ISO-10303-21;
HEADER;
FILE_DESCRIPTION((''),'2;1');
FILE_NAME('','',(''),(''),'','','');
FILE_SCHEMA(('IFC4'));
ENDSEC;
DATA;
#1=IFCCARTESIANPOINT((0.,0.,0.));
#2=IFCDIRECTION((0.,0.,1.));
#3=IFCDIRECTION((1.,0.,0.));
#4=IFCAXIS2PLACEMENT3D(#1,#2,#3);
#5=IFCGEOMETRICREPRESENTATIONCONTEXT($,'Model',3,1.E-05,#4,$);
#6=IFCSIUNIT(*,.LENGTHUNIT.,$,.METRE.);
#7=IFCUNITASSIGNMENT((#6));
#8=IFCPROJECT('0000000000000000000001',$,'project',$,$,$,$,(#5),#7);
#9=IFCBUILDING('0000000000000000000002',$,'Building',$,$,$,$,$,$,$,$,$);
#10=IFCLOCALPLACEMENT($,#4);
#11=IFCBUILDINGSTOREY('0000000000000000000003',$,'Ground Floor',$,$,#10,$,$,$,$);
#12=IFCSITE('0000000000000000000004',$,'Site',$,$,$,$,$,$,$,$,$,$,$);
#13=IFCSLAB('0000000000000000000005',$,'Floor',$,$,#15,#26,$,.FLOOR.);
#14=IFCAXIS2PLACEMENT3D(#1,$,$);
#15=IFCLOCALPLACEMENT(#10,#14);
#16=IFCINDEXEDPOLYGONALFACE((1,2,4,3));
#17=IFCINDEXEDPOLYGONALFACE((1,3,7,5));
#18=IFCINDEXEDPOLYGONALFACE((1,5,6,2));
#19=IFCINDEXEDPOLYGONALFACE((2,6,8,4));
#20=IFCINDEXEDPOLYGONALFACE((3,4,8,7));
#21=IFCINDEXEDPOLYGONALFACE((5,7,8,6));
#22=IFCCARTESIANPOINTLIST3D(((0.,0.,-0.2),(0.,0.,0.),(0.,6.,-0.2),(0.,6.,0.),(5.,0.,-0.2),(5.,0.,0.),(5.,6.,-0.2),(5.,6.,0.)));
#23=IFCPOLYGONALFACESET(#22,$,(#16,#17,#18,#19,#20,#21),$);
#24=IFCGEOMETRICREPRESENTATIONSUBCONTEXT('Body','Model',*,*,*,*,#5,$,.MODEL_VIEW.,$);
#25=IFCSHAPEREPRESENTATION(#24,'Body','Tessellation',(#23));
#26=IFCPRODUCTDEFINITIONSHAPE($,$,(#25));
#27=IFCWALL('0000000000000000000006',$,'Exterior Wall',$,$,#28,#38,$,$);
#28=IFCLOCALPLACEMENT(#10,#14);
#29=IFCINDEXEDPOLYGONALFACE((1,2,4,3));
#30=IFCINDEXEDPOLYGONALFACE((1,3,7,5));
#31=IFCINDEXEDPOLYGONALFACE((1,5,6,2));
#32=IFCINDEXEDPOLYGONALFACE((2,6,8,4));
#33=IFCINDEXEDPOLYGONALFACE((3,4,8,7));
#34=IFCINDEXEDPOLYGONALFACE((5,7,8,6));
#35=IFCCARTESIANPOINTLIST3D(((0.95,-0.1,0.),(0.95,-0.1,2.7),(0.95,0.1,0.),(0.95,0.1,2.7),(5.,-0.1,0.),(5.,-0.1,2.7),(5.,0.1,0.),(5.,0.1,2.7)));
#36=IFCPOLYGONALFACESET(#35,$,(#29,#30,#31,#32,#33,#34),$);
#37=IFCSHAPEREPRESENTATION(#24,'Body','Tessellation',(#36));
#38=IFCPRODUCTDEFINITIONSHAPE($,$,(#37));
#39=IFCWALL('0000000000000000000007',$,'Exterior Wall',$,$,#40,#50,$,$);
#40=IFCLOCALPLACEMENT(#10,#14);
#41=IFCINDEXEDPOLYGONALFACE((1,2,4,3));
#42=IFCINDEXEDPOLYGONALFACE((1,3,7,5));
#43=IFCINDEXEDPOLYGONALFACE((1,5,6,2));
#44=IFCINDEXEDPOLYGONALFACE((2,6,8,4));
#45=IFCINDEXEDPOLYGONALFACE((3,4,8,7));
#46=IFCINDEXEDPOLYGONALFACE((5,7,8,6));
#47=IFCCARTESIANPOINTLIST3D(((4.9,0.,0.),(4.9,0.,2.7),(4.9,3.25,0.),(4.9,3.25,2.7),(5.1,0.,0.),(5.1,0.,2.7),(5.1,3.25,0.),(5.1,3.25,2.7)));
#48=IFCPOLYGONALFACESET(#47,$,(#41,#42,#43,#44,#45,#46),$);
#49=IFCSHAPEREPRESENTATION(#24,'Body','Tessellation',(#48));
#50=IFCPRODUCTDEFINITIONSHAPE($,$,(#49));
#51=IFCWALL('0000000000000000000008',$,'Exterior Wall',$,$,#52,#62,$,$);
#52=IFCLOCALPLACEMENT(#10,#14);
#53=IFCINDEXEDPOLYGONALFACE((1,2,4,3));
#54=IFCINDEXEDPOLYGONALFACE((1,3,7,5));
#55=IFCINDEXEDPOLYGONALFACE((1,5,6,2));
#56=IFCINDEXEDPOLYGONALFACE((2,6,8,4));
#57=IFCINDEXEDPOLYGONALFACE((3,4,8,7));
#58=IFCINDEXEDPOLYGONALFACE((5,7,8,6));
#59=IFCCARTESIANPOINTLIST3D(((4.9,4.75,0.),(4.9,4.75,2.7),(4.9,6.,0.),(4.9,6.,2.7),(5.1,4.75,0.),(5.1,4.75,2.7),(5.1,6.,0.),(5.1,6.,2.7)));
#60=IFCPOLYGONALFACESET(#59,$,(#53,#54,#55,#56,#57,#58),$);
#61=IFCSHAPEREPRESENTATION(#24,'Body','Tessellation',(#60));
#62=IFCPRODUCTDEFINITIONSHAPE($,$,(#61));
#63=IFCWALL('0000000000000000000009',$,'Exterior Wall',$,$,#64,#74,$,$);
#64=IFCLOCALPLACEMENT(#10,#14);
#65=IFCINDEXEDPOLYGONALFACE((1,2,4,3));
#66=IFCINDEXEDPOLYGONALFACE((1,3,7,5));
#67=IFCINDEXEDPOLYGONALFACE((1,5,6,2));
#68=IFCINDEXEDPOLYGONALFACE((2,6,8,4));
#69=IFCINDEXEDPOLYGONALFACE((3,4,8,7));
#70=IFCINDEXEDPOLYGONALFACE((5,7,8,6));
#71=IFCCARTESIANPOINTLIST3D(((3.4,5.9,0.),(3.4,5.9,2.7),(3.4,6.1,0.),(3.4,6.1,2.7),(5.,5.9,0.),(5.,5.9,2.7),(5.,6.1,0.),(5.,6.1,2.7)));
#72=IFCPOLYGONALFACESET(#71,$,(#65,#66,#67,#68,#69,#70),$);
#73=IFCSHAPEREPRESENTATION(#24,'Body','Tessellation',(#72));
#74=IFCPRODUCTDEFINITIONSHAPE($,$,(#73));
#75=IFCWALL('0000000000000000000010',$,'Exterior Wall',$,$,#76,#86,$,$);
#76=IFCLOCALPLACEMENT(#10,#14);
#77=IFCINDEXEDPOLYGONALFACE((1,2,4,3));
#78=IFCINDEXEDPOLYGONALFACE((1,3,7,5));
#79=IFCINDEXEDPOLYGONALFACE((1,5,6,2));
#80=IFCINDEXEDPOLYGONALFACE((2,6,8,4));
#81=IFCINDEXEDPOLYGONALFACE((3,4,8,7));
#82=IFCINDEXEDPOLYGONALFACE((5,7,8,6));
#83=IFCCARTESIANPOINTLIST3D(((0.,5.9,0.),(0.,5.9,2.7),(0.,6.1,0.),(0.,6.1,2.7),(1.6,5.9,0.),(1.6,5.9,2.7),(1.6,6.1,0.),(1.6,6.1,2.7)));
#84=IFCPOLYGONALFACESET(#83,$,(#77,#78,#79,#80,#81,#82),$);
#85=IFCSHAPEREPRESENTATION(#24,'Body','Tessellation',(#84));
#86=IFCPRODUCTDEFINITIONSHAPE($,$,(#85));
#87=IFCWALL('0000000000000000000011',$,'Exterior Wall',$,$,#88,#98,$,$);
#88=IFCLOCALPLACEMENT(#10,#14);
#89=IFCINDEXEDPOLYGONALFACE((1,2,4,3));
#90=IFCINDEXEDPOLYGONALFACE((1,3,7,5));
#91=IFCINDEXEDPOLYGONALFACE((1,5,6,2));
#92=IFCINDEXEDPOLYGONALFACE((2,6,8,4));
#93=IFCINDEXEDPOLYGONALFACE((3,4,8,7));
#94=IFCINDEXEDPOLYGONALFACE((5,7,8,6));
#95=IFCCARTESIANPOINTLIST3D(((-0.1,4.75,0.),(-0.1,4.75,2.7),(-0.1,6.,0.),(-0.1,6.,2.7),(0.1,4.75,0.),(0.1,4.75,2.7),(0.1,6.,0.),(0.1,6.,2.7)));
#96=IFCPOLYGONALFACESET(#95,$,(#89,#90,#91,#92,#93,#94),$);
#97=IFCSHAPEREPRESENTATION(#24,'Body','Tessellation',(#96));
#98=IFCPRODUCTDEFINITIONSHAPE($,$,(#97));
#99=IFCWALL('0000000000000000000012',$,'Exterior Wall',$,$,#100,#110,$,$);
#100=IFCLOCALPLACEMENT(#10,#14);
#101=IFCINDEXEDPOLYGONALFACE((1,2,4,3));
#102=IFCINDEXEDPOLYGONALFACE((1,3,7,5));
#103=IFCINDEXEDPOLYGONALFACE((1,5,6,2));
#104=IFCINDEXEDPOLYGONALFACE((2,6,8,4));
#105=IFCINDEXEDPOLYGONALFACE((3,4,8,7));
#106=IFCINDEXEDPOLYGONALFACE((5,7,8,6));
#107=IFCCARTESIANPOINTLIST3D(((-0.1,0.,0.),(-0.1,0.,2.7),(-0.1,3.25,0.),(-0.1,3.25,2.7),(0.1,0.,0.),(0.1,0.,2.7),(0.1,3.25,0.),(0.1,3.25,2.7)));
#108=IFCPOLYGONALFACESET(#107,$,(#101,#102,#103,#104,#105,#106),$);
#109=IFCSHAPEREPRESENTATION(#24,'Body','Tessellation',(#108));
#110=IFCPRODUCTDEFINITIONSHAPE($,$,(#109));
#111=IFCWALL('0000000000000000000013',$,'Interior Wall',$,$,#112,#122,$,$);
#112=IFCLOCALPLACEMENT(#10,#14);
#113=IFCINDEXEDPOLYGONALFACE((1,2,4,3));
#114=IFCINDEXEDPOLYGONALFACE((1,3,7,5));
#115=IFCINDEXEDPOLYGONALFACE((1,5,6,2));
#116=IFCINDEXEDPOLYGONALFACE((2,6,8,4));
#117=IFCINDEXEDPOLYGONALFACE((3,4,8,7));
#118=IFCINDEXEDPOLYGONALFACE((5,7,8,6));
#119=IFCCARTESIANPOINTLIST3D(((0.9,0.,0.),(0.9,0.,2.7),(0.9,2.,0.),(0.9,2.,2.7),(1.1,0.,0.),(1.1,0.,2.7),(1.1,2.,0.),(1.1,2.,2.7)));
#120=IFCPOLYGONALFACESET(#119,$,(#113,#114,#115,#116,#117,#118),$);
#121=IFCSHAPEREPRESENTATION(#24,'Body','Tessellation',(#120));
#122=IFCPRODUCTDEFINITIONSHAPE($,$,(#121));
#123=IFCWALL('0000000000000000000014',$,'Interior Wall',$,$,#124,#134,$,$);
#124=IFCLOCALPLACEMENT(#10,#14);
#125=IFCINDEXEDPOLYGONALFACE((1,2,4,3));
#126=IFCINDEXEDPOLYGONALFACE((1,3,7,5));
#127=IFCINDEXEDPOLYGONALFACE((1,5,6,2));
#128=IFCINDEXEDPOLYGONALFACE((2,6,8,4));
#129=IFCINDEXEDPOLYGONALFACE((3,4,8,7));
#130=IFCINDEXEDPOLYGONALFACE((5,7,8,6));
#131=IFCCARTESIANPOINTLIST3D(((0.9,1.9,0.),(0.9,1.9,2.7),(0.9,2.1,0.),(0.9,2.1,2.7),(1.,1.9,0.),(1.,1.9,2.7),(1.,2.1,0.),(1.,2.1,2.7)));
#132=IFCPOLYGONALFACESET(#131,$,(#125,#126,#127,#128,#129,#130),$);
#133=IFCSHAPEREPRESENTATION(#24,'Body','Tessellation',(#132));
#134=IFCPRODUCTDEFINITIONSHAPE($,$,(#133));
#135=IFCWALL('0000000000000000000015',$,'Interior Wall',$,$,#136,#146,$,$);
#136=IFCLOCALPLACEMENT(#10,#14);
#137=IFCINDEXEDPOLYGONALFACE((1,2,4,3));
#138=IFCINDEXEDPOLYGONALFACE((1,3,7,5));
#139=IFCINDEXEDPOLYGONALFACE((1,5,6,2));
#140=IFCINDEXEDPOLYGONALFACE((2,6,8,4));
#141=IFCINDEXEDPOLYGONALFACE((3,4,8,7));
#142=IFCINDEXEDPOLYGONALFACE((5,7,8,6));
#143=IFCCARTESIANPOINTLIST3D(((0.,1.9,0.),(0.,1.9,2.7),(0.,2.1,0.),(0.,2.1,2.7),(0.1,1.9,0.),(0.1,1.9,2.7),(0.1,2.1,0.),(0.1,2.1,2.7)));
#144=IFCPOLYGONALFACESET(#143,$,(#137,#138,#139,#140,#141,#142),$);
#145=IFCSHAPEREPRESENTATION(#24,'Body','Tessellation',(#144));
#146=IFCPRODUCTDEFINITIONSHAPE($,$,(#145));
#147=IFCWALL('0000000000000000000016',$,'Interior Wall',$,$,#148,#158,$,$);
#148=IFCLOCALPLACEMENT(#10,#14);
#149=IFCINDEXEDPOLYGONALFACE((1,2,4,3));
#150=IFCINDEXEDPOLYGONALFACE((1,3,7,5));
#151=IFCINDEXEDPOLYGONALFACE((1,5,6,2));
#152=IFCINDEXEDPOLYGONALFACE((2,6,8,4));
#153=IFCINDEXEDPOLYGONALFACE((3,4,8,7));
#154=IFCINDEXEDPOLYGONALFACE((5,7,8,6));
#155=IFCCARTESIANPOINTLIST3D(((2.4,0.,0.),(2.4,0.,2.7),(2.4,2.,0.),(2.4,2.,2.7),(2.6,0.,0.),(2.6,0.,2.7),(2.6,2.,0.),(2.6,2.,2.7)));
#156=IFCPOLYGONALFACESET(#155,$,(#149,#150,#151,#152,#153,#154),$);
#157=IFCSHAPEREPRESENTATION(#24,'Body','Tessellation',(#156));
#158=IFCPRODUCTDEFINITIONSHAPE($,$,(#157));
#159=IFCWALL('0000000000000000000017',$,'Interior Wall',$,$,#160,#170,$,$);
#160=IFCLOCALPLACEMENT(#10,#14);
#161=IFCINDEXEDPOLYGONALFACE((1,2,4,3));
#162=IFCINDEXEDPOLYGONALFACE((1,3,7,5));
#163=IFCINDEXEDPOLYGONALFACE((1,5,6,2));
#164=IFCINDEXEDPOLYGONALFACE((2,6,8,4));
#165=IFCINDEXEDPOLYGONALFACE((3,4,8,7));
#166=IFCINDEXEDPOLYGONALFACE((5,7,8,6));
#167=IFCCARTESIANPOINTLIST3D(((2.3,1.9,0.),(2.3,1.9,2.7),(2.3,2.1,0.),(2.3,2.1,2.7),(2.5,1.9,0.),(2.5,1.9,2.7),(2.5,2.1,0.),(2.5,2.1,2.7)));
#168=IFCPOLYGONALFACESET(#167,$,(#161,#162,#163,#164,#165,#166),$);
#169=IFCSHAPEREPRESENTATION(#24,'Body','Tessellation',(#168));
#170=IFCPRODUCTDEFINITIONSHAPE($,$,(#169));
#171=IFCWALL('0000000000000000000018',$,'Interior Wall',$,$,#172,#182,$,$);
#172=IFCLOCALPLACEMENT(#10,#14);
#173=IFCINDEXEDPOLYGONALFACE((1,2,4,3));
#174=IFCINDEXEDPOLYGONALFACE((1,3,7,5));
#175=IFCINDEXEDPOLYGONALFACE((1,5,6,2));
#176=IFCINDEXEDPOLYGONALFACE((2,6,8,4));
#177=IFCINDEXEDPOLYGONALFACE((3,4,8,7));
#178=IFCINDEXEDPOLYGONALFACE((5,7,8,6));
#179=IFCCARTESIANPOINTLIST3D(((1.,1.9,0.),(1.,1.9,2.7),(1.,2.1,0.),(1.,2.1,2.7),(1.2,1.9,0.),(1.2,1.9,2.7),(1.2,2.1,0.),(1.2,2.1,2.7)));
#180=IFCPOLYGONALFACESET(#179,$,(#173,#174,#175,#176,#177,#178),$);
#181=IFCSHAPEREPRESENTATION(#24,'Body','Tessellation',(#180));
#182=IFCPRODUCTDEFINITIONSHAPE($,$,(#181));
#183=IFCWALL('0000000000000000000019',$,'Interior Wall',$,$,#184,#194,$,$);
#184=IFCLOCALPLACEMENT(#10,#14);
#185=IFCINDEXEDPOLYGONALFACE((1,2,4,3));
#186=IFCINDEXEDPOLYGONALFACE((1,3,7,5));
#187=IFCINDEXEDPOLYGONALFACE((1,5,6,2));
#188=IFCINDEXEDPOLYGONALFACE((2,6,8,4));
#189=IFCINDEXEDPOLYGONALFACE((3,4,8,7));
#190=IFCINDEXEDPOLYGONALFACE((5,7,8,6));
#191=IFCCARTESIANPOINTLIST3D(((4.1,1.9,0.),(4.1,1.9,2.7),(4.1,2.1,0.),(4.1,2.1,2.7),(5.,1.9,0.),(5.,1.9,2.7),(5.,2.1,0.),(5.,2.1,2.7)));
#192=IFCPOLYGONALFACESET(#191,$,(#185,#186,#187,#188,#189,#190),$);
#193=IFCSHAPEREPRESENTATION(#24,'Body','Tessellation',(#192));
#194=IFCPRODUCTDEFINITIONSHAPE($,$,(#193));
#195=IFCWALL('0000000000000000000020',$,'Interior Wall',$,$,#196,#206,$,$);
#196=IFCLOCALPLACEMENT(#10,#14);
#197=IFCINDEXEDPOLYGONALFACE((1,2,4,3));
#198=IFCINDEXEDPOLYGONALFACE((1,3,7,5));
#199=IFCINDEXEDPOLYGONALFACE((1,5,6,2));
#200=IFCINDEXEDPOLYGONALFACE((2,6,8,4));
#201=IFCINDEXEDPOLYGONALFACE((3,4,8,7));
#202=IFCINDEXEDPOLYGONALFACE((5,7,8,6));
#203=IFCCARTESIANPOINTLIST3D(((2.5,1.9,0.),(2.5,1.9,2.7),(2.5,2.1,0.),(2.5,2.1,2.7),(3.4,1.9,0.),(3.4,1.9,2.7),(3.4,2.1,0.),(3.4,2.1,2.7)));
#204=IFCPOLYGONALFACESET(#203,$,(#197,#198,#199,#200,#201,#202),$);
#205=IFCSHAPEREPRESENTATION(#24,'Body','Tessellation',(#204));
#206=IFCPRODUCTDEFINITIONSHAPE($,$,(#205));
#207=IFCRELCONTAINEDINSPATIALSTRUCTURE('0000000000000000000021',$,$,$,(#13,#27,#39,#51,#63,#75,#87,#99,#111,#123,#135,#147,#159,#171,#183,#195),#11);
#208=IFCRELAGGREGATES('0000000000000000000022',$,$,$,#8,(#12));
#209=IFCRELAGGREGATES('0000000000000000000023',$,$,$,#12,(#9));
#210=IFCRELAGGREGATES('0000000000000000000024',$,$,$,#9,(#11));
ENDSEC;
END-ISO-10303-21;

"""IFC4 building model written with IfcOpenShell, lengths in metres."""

from ifc_helpers import new_model, si_unit, frame, origin_with_axes, place, context, subcontext, project, spatial, indexed_curve, outline, extrude, element, save


model = new_model("IFC4")

# Units and contexts
model_context = context("Model", 3, precision=1e-05, world=origin_with_axes())
body_context = subcontext(model_context, "Body", "Model", "MODEL_VIEW")
ifc_project = project(units=[si_unit("LENGTHUNIT", "METRE")], contexts=[model_context])

# Site, building, storey
site = spatial("IfcSite", under=ifc_project, Name="Site")
building = spatial("IfcBuilding", under=site, Name="Building")
storey_placement = place(None, origin_with_axes())
storey = spatial("IfcBuildingStorey", under=building, at=storey_placement, Name="Ground Floor")

# Slab
slab_placement = place(storey_placement, frame((0.0, 0.0, -0.2), z_axis=(0.0, 0.0, 1.0), x_axis=(1.0, 0.0, 0.0)))
element("IfcSlab", 1, at=slab_placement, inside=storey, Name="Floor", PredefinedType="FLOOR", context=body_context, shape_type="SweptSolid", body=[
    extrude(outline(indexed_curve([(0.0, 0.0), (5.0, 0.0), (5.0, 6.0), (0.0, 6.0)])), None, (0.0, 0.0, 1.0), 0.2),
])

# Walls
wall_1_placement = place(storey_placement, frame((0.95, 0.0, 0.0), z_axis=(0.0, 0.0, 1.0), x_axis=(1.0, 0.0, 0.0)))
element("IfcWall", 2, at=wall_1_placement, inside=storey, Name="Exterior Wall", context=body_context, shape_type="SweptSolid", body=[
    extrude(outline(indexed_curve([(0.0, 0.0), (0.0, 0.2), (4.05, 0.2), (4.05, 0.0), (0.0, 0.0)], self_intersect=False)), frame((0.0, -0.1, 0.0), z_axis=(0.0, 0.0, 1.0), x_axis=(1.0, 0.0, 0.0)), (0.0, 0.0, 1.0), 2.7),
])
wall_2_placement = place(storey_placement, frame((5.0, 0.0, 0.0), z_axis=(0.0, 0.0, 1.0), x_axis=(0.0, 1.0, 0.0)))
element("IfcWall", 3, at=wall_2_placement, inside=storey, Name="Exterior Wall", context=body_context, shape_type="SweptSolid", body=[
    extrude(outline(indexed_curve([(0.0, 0.0), (0.0, 0.2), (3.25, 0.2), (3.25, 0.0), (0.0, 0.0)], self_intersect=False)), frame((0.0, -0.1, 0.0), z_axis=(0.0, 0.0, 1.0), x_axis=(1.0, 0.0, 0.0)), (0.0, 0.0, 1.0), 2.7),
])
wall_3_placement = place(storey_placement, frame((5.0, 4.75, 0.0), z_axis=(0.0, 0.0, 1.0), x_axis=(0.0, 1.0, 0.0)))
element("IfcWall", 4, at=wall_3_placement, inside=storey, Name="Exterior Wall", context=body_context, shape_type="SweptSolid", body=[
    extrude(outline(indexed_curve([(0.0, 0.0), (0.0, 0.2), (1.25, 0.2), (1.25, 0.0), (0.0, 0.0)], self_intersect=False)), frame((0.0, -0.1, 0.0), z_axis=(0.0, 0.0, 1.0), x_axis=(1.0, 0.0, 0.0)), (0.0, 0.0, 1.0), 2.7),
])
for number, where, z_axis, x_axis, name in (
    (5, (5.0, 6.0, 0.0), (0.0, 0.0, 1.0), (-1.0, 0.0, 0.0), "Exterior Wall"),
    (6, (1.6, 6.0, 0.0), (0.0, 0.0, 1.0), (-1.0, 0.0, 0.0), "Exterior Wall"),
):
    element("IfcWall", number, at=place(storey_placement, frame(where, z_axis=z_axis, x_axis=x_axis)), inside=storey, Name=name, context=body_context, shape_type="SweptSolid", body=[
        extrude(outline(indexed_curve([(0.0, 0.0), (0.0, 0.2), (1.6, 0.2), (1.6, 0.0), (0.0, 0.0)], self_intersect=False)), frame((0.0, -0.1, 0.0), z_axis=(0.0, 0.0, 1.0), x_axis=(1.0, 0.0, 0.0)), (0.0, 0.0, 1.0), 2.7),
    ])
wall_4_placement = place(storey_placement, frame((0.0, 6.0, 0.0), z_axis=(0.0, 0.0, 1.0), x_axis=(0.0, -1.0, 0.0)))
element("IfcWall", 7, at=wall_4_placement, inside=storey, Name="Exterior Wall", context=body_context, shape_type="SweptSolid", body=[
    extrude(outline(indexed_curve([(0.0, 0.0), (0.0, 0.2), (1.25, 0.2), (1.25, 0.0), (0.0, 0.0)], self_intersect=False)), frame((0.0, -0.1, 0.0), z_axis=(0.0, 0.0, 1.0), x_axis=(1.0, 0.0, 0.0)), (0.0, 0.0, 1.0), 2.7),
])
wall_5_placement = place(storey_placement, frame((0.0, 3.25, 0.0), z_axis=(0.0, 0.0, 1.0), x_axis=(0.0, -1.0, 0.0)))
element("IfcWall", 8, at=wall_5_placement, inside=storey, Name="Exterior Wall", context=body_context, shape_type="SweptSolid", body=[
    extrude(outline(indexed_curve([(0.0, 0.0), (0.0, 0.2), (3.25, 0.2), (3.25, 0.0), (0.0, 0.0)], self_intersect=False)), frame((0.0, -0.1, 0.0), z_axis=(0.0, 0.0, 1.0), x_axis=(1.0, 0.0, 0.0)), (0.0, 0.0, 1.0), 2.7),
])
wall_6_placement = place(storey_placement, frame((1.0, 0.0, 0.0), z_axis=(0.0, 0.0, 1.0), x_axis=(0.0, 1.0, 0.0)))
element("IfcWall", 9, at=wall_6_placement, inside=storey, Name="Interior Wall", context=body_context, shape_type="SweptSolid", body=[
    extrude(outline(indexed_curve([(0.0, 0.0), (0.0, 0.2), (2.0, 0.2), (2.0, 0.0), (0.0, 0.0)], self_intersect=False)), frame((0.0, -0.1, 0.0), z_axis=(0.0, 0.0, 1.0), x_axis=(1.0, 0.0, 0.0)), (0.0, 0.0, 1.0), 2.7),
])
for number, where, z_axis, x_axis, name in (
    (10, (1.0, 2.0, 0.0), (0.0, 0.0, 1.0), (-1.0, 0.0, 0.0), "Interior Wall"),
    (11, (0.1, 2.0, 0.0), (0.0, 0.0, 1.0), (-1.0, 0.0, 0.0), "Interior Wall"),
):
    element("IfcWall", number, at=place(storey_placement, frame(where, z_axis=z_axis, x_axis=x_axis)), inside=storey, Name=name, context=body_context, shape_type="SweptSolid", body=[
        extrude(outline(indexed_curve([(0.0, 0.0), (0.0, 0.2), (0.1, 0.2), (0.1, 0.0), (0.0, 0.0)], self_intersect=False)), frame((0.0, -0.1, 0.0), z_axis=(0.0, 0.0, 1.0), x_axis=(1.0, 0.0, 0.0)), (0.0, 0.0, 1.0), 2.7),
    ])
wall_7_placement = place(storey_placement, frame((2.5, 0.0, 0.0), z_axis=(0.0, 0.0, 1.0), x_axis=(0.0, 1.0, 0.0)))
element("IfcWall", 12, at=wall_7_placement, inside=storey, Name="Interior Wall", context=body_context, shape_type="SweptSolid", body=[
    extrude(outline(indexed_curve([(0.0, 0.0), (0.0, 0.2), (2.0, 0.2), (2.0, 0.0), (0.0, 0.0)], self_intersect=False)), frame((0.0, -0.1, 0.0), z_axis=(0.0, 0.0, 1.0), x_axis=(1.0, 0.0, 0.0)), (0.0, 0.0, 1.0), 2.7),
])
wall_8_placement = place(storey_placement, frame((2.5, 2.0, 0.0), z_axis=(0.0, 0.0, 1.0), x_axis=(-1.0, 0.0, 0.0)))
element("IfcWall", 13, at=wall_8_placement, inside=storey, Name="Interior Wall", context=body_context, shape_type="SweptSolid", body=[
    extrude(outline(indexed_curve([(0.0, 0.0), (0.0, 0.2), (0.2, 0.2), (0.2, 0.0), (0.0, 0.0)], self_intersect=False)), frame((0.0, -0.1, 0.0), z_axis=(0.0, 0.0, 1.0), x_axis=(1.0, 0.0, 0.0)), (0.0, 0.0, 1.0), 2.7),
])
wall_9_placement = place(storey_placement, frame((1.2, 2.0, 0.0), z_axis=(0.0, 0.0, 1.0), x_axis=(-1.0, 0.0, 0.0)))
element("IfcWall", 14, at=wall_9_placement, inside=storey, Name="Interior Wall", context=body_context, shape_type="SweptSolid", body=[
    extrude(outline(indexed_curve([(0.0, 0.0), (0.0, 0.2), (0.2, 0.2), (0.2, 0.0), (0.0, 0.0)], self_intersect=False)), frame((0.0, -0.1, 0.0), z_axis=(0.0, 0.0, 1.0), x_axis=(1.0, 0.0, 0.0)), (0.0, 0.0, 1.0), 2.7),
])
wall_10_placement = place(storey_placement, frame((5.0, 2.0, 0.0), z_axis=(0.0, 0.0, 1.0), x_axis=(-1.0, 0.0, 0.0)))
element("IfcWall", 15, at=wall_10_placement, inside=storey, Name="Interior Wall", context=body_context, shape_type="SweptSolid", body=[
    extrude(outline(indexed_curve([(0.0, 0.0), (0.0, 0.2), (0.9, 0.2), (0.9, 0.0), (0.0, 0.0)], self_intersect=False)), frame((0.0, -0.1, 0.0), z_axis=(0.0, 0.0, 1.0), x_axis=(1.0, 0.0, 0.0)), (0.0, 0.0, 1.0), 2.7),
])
wall_11_placement = place(storey_placement, frame((3.4, 2.0, 0.0), z_axis=(0.0, 0.0, 1.0), x_axis=(-1.0, 0.0, 0.0)))
element("IfcWall", 16, at=wall_11_placement, inside=storey, Name="Interior Wall", context=body_context, shape_type="SweptSolid", body=[
    extrude(outline(indexed_curve([(0.0, 0.0), (0.0, 0.2), (0.9, 0.2), (0.9, 0.0), (0.0, 0.0)], self_intersect=False)), frame((0.0, -0.1, 0.0), z_axis=(0.0, 0.0, 1.0), x_axis=(1.0, 0.0, 0.0)), (0.0, 0.0, 1.0), 2.7),
])

save(model, "model.ifc")
